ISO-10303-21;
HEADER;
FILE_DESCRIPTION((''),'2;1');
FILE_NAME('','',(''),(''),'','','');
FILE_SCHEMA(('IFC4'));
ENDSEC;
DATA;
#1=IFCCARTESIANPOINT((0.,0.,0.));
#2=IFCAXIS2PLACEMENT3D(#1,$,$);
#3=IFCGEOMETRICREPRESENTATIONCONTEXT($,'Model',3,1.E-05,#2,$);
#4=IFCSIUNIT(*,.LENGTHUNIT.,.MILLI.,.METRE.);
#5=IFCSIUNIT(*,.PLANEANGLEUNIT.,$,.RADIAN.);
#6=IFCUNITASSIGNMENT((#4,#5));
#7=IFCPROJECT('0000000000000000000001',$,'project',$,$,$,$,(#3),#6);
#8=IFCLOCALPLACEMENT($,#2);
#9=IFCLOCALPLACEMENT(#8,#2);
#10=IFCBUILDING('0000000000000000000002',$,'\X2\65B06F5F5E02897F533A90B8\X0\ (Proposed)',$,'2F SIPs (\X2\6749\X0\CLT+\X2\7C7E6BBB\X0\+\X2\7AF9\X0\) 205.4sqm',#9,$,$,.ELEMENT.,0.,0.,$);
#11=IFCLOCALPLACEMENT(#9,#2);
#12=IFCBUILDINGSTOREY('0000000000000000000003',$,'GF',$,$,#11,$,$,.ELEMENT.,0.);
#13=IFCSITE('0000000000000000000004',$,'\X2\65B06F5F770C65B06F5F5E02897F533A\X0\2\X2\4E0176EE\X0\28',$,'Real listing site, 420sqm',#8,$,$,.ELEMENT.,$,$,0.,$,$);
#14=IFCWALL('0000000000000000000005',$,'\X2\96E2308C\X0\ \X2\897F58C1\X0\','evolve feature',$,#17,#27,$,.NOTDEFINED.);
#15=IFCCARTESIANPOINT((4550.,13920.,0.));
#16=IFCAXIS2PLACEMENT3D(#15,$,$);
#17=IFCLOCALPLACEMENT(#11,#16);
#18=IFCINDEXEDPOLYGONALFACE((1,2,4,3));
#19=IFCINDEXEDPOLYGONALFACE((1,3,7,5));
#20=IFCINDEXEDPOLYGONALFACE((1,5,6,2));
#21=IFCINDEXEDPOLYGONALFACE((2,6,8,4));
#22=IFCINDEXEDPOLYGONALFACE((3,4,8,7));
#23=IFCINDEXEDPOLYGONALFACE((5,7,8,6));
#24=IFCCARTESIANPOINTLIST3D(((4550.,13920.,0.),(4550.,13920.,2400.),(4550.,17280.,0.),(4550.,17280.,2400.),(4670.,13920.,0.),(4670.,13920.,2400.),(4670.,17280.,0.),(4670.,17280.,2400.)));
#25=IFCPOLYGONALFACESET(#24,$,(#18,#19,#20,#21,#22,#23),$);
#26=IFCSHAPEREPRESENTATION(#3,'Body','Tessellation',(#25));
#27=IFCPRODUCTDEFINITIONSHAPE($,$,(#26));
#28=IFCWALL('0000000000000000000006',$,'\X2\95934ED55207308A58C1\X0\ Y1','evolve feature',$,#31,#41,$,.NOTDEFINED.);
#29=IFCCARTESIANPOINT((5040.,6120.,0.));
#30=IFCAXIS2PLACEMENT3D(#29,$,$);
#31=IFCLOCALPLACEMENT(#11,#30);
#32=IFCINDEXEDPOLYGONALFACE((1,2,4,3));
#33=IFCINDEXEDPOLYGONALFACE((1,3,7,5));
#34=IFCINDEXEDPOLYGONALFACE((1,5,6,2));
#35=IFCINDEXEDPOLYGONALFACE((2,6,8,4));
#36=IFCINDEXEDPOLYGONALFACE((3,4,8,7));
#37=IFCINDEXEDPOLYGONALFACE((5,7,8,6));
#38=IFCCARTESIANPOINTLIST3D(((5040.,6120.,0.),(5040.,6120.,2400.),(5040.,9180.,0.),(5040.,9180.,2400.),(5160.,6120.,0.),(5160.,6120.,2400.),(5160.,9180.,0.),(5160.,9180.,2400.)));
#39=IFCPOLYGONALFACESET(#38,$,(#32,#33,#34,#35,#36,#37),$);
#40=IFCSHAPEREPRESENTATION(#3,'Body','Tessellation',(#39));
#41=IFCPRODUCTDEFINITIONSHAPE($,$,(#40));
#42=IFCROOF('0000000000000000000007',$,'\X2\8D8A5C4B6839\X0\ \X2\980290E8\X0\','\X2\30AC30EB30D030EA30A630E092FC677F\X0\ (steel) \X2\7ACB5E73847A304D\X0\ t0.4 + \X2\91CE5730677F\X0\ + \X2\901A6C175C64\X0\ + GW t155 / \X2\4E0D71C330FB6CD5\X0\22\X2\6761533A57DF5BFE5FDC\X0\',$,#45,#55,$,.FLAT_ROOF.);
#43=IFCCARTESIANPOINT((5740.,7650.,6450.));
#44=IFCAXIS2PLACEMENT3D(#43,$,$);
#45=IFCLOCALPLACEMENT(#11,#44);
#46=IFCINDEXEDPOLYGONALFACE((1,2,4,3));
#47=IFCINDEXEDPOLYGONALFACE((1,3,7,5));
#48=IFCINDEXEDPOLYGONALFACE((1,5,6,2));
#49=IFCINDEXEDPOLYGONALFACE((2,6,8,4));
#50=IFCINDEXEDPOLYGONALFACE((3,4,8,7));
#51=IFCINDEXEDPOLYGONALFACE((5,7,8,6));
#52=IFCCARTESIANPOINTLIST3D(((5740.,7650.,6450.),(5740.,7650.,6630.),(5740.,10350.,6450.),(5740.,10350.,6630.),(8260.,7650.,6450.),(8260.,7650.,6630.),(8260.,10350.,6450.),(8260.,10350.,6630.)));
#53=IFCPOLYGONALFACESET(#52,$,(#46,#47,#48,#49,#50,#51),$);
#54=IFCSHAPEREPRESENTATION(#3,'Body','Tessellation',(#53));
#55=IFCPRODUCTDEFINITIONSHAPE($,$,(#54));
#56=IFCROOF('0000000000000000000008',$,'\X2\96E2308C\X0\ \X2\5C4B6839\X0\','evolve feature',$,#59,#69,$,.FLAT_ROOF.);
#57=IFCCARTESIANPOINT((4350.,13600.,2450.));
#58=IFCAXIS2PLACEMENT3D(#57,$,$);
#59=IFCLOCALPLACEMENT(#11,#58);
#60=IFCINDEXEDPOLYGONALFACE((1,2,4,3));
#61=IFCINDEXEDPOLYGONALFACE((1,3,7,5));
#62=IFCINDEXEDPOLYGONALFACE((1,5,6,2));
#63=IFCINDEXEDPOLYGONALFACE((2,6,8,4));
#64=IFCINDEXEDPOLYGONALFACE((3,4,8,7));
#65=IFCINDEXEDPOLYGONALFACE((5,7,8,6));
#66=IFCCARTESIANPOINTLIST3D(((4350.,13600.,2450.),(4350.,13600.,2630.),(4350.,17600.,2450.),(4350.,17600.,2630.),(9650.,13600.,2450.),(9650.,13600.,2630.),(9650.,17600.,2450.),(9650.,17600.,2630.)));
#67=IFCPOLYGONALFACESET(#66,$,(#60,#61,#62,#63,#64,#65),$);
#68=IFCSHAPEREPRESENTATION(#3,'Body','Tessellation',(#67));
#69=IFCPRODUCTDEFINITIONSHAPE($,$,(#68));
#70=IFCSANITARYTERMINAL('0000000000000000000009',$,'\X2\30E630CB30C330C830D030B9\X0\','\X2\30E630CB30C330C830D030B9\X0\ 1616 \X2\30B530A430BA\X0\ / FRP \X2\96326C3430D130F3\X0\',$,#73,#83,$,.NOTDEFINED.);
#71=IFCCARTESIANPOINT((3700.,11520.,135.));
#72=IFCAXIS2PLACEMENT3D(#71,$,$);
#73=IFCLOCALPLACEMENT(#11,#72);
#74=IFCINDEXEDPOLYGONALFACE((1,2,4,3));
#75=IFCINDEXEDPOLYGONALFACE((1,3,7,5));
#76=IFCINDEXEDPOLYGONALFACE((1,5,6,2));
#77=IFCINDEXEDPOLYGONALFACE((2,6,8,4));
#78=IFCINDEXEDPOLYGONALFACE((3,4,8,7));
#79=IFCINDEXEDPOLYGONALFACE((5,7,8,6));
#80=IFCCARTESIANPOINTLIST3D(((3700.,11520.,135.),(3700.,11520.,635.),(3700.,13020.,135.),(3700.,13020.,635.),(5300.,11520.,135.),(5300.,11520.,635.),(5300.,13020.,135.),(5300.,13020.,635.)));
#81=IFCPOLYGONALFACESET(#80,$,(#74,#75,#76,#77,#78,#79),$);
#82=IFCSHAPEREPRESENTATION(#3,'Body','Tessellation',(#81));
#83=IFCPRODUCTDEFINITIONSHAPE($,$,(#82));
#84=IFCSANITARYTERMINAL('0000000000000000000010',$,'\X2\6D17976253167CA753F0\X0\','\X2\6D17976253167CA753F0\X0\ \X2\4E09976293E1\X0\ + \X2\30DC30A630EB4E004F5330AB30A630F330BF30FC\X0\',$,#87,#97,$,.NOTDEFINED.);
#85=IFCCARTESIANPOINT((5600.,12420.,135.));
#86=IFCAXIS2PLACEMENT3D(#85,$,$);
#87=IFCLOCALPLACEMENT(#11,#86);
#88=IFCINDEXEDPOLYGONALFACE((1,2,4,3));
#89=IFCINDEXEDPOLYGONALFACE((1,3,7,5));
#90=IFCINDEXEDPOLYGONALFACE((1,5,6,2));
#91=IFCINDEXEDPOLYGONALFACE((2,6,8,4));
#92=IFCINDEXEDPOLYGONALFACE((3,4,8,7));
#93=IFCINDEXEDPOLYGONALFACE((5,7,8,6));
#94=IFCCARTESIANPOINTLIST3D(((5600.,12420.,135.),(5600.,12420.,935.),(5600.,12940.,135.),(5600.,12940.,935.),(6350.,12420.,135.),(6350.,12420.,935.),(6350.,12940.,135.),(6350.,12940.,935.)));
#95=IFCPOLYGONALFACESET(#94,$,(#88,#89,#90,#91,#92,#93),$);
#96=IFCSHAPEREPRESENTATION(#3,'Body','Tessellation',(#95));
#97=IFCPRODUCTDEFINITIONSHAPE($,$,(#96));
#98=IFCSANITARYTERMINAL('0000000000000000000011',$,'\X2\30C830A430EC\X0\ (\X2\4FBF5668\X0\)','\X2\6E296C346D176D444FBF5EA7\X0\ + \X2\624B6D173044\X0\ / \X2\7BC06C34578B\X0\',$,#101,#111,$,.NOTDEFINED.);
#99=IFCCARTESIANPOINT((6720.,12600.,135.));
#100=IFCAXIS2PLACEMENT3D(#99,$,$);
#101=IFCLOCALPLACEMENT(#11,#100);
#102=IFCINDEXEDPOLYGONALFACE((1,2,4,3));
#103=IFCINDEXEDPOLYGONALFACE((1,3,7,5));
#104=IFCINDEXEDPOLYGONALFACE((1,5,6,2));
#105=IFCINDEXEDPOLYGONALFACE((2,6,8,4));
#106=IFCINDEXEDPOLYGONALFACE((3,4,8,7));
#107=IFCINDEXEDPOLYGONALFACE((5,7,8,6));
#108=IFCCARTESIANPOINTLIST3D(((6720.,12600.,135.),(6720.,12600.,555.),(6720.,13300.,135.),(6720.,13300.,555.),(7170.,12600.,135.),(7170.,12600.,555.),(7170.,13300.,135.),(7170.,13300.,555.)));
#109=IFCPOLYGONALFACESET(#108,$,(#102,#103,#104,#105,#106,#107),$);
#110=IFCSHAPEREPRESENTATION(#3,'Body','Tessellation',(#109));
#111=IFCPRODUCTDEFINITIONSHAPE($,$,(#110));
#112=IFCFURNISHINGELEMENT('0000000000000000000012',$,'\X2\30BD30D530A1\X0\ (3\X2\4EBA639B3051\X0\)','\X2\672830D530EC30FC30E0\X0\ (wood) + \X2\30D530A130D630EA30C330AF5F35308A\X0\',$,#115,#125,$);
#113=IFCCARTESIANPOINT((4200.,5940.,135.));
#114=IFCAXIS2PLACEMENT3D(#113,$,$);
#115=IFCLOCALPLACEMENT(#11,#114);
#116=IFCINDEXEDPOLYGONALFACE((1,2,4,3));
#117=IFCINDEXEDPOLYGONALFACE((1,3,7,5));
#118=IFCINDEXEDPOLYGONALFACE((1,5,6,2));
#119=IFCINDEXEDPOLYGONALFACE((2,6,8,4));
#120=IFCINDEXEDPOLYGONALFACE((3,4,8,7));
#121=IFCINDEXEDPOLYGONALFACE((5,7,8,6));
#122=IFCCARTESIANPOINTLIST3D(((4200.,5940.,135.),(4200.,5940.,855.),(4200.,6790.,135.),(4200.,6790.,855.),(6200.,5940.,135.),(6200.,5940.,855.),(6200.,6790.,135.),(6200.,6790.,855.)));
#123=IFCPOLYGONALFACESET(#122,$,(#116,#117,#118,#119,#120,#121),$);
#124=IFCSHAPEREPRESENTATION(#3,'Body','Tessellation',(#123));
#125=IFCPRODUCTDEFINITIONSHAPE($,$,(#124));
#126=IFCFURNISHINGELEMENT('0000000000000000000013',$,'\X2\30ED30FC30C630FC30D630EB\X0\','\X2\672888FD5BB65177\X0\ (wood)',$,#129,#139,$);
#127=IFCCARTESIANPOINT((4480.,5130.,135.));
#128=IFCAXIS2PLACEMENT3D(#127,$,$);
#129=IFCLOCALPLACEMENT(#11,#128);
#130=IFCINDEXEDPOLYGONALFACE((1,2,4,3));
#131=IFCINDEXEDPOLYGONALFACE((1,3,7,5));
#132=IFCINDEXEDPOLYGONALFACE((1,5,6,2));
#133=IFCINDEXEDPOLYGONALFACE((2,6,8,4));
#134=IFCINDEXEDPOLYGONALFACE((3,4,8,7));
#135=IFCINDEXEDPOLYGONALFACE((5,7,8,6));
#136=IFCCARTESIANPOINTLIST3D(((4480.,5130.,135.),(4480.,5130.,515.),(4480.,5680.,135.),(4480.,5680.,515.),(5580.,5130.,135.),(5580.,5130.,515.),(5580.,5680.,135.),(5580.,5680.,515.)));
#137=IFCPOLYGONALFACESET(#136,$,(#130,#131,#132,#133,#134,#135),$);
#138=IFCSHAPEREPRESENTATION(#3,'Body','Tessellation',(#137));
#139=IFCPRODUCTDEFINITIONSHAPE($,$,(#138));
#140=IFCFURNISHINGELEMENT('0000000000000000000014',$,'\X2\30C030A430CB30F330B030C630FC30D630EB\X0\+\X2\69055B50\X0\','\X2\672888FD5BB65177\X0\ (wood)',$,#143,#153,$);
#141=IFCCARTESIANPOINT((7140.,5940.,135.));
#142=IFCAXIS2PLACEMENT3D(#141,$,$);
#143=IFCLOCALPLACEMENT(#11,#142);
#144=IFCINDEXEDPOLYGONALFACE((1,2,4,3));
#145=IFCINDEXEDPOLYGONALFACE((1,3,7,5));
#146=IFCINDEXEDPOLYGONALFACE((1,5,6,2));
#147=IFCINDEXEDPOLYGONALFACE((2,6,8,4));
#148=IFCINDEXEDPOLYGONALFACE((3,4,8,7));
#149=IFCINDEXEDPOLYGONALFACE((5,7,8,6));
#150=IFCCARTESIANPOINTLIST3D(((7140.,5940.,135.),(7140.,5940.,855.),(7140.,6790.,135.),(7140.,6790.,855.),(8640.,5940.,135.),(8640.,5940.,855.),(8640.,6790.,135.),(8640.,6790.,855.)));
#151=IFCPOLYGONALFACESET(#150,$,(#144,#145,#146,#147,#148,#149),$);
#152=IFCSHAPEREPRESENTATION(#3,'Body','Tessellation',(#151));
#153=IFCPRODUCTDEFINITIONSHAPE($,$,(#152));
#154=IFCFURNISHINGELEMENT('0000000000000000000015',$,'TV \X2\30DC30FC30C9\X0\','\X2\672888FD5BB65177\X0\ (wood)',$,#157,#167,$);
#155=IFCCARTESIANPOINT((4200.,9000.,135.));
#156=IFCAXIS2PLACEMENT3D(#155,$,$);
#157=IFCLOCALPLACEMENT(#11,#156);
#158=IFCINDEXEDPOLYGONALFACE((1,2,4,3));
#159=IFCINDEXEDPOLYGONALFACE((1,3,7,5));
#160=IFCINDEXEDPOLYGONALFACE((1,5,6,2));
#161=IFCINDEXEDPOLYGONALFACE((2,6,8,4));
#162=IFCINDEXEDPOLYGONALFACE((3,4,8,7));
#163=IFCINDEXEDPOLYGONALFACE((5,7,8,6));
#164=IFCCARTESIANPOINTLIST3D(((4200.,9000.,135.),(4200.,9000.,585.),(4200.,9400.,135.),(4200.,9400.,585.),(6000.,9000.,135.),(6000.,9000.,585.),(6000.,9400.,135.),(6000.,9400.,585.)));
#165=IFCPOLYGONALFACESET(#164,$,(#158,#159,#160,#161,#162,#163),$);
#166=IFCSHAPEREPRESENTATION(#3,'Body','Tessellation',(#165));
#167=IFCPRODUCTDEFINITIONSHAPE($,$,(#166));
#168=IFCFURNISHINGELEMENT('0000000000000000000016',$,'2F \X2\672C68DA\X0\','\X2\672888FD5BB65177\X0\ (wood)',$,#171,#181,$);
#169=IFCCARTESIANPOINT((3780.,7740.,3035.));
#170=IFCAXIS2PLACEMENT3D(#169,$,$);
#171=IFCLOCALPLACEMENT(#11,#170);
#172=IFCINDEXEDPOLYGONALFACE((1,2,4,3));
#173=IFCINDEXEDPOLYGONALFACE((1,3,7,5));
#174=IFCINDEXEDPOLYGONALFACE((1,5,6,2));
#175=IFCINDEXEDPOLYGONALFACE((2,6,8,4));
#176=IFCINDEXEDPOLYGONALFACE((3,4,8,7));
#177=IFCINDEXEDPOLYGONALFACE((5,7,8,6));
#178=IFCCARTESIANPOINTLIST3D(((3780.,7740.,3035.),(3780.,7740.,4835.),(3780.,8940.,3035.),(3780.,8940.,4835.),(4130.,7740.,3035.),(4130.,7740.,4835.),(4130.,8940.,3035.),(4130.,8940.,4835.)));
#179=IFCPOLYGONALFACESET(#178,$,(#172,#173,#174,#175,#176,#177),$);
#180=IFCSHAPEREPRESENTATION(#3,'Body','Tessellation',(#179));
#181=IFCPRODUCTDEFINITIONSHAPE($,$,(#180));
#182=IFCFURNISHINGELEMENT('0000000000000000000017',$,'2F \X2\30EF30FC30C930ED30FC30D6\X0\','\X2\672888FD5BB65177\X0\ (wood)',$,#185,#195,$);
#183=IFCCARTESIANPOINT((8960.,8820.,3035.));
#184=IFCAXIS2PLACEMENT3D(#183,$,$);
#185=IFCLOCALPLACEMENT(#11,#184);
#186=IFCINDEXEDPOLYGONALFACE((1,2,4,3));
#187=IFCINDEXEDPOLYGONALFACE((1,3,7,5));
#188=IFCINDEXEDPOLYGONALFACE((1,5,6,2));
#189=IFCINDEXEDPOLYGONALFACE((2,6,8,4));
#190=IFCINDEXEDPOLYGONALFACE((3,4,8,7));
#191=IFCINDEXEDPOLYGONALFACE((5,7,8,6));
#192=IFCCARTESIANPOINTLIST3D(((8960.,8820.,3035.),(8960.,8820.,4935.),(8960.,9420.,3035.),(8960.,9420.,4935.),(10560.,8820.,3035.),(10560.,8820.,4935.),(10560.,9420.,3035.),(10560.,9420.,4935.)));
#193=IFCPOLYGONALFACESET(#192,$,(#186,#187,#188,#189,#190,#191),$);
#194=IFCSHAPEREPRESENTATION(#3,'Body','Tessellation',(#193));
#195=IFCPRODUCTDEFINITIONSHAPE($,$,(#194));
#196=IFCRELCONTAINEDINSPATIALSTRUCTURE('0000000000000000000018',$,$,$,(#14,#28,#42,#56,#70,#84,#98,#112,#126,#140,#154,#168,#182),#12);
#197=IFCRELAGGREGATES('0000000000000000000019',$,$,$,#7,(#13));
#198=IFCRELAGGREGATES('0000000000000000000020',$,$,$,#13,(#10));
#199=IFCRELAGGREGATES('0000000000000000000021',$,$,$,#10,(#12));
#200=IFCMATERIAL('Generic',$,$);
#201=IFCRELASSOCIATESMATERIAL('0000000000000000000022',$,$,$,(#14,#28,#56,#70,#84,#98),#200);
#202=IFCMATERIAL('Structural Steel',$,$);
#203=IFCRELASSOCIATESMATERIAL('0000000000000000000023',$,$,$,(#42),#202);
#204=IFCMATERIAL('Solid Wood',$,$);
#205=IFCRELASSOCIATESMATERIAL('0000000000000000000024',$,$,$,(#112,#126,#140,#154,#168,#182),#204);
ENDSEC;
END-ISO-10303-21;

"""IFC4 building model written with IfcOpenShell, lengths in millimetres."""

from ifc_helpers import new_model, si_unit, frame, frame_2d, origin, place, context, project, spatial, rectangle, extrude, material, element, save


model = new_model("IFC4")

# Units and contexts
model_context = context("Model", 3, precision=1e-05, world=origin())
ifc_project = project(units=[si_unit("LENGTHUNIT", "METRE", prefix="MILLI"), si_unit("PLANEANGLEUNIT", "RADIAN")], contexts=[model_context])

# Site, building, storey
site_placement = place(None, origin())
site = spatial("IfcSite", under=ifc_project, at=site_placement, Name="新潟県新潟市西区2丁目28", ObjectType="Real listing site, 420sqm", CompositionType="ELEMENT", RefElevation=0.0)
building_placement = place(site_placement, origin())
building = spatial("IfcBuilding", under=site, at=building_placement, Name="新潟市西区邸 (Proposed)", ObjectType="2F SIPs (杉CLT+籾殻+竹) 205.4sqm", CompositionType="ELEMENT", ElevationOfRefHeight=0.0, ElevationOfTerrain=0.0)
storey_placement = place(building_placement, origin())
storey = spatial("IfcBuildingStorey", under=building, at=storey_placement, Name="GF", CompositionType="ELEMENT", Elevation=0.0)

# Shared definitions
ifc_material_1 = material(Name="Generic")

# Shared definitions
ifc_material_2 = material(Name="Solid Wood")

# Walls
wall_1_placement = place(storey_placement, frame((4550.0, 13920.0, 0.0)))
element("IfcWall", 1, at=wall_1_placement, inside=storey, material=ifc_material_1, Name="離れ 西壁", Description="evolve feature", PredefinedType="NOTDEFINED", context=model_context, shape_type="SweptSolid", body=[
    extrude(rectangle(XDim=120.0, YDim=3360.0, at=frame_2d((60.0, 1680.0))), frame((4550.0, 13920.0, 0.0)), (0.0, 0.0, 1.0), 2400.0),
])
wall_2_placement = place(storey_placement, frame((5040.0, 6120.0, 0.0)))
element("IfcWall", 2, at=wall_2_placement, inside=storey, material=ifc_material_1, Name="間仕切り壁 Y1", Description="evolve feature", PredefinedType="NOTDEFINED", context=model_context, shape_type="SweptSolid", body=[
    extrude(rectangle(XDim=120.0, YDim=3060.0, at=frame_2d((60.0, 1530.0))), frame((5040.0, 6120.0, 0.0)), (0.0, 0.0, 1.0), 2400.0),
])

# Roofs
ifc_material_3 = material(Name="Structural Steel")
roof_1_placement = place(storey_placement, frame((5740.0, 7650.0, 6450.0)))
element("IfcRoof", 3, at=roof_1_placement, inside=storey, material=ifc_material_3, Name="越屋根 頂部", Description="ガルバリウム鋼板 (steel) 立平葺き t0.4 + 野地板 + 通気層 + GW t155 / 不燃・法22条区域対応", PredefinedType="FLAT_ROOF", context=model_context, shape_type="SweptSolid", body=[
    extrude(rectangle(XDim=2520.0, YDim=2700.0, at=frame_2d((1260.0, 1350.0))), frame((5740.0, 7650.0, 6450.0)), (0.0, 0.0, 1.0), 180.0),
])
roof_2_placement = place(storey_placement, frame((4350.0, 13600.0, 2450.0)))
element("IfcRoof", 4, at=roof_2_placement, inside=storey, material=ifc_material_1, Name="離れ 屋根", Description="evolve feature", PredefinedType="FLAT_ROOF", context=model_context, shape_type="SweptSolid", body=[
    extrude(rectangle(XDim=5300.0, YDim=4000.0, at=frame_2d((2650.0, 2000.0))), frame((4350.0, 13600.0, 2450.0)), (0.0, 0.0, 1.0), 180.0),
])

# Sanitary terminals
sanitary_terminal_1_placement = place(storey_placement, frame((3700.0, 11520.0, 135.0)))
element("IfcSanitaryTerminal", 5, at=sanitary_terminal_1_placement, inside=storey, material=ifc_material_1, Name="ユニットバス", Description="ユニットバス 1616 サイズ / FRP 防水パン", PredefinedType="NOTDEFINED", context=model_context, shape_type="SweptSolid", body=[
    extrude(rectangle(XDim=1600.0, YDim=1500.0, at=frame_2d((800.0, 750.0))), frame((3700.0, 11520.0, 135.0)), (0.0, 0.0, 1.0), 500.0),
])
sanitary_terminal_2_placement = place(storey_placement, frame((5600.0, 12420.0, 135.0)))
element("IfcSanitaryTerminal", 6, at=sanitary_terminal_2_placement, inside=storey, material=ifc_material_1, Name="洗面化粧台", Description="洗面化粧台 三面鏡 + ボウル一体カウンター", PredefinedType="NOTDEFINED", context=model_context, shape_type="SweptSolid", body=[
    extrude(rectangle(XDim=750.0, YDim=520.0, at=frame_2d((375.0, 260.0))), frame((5600.0, 12420.0, 135.0)), (0.0, 0.0, 1.0), 800.0),
])
sanitary_terminal_3_placement = place(storey_placement, frame((6720.0, 12600.0, 135.0)))
element("IfcSanitaryTerminal", 7, at=sanitary_terminal_3_placement, inside=storey, material=ifc_material_1, Name="トイレ (便器)", Description="温水洗浄便座 + 手洗い / 節水型", PredefinedType="NOTDEFINED", context=model_context, shape_type="SweptSolid", body=[
    extrude(rectangle(XDim=450.0, YDim=700.0, at=frame_2d((225.0, 350.0))), frame((6720.0, 12600.0, 135.0)), (0.0, 0.0, 1.0), 420.0),
])

# Furnishing elements
furnishing_1_placement = place(storey_placement, frame((4200.0, 5940.0, 135.0)))
element("IfcFurnishingElement", 8, at=furnishing_1_placement, inside=storey, material=ifc_material_2, Name="ソファ (3人掛け)", Description="木フレーム (wood) + ファブリック張り", context=model_context, shape_type="SweptSolid", body=[
    extrude(rectangle(XDim=2000.0, YDim=850.0, at=frame_2d((1000.0, 425.0))), frame((4200.0, 5940.0, 135.0)), (0.0, 0.0, 1.0), 720.0),
])
furnishing_2_placement = place(storey_placement, frame((4480.0, 5130.0, 135.0)))
element("IfcFurnishingElement", 9, at=furnishing_2_placement, inside=storey, material=ifc_material_2, Name="ローテーブル", Description="木製家具 (wood)", context=model_context, shape_type="SweptSolid", body=[
    extrude(rectangle(XDim=1100.0, YDim=550.0, at=frame_2d((550.0, 275.0))), frame((4480.0, 5130.0, 135.0)), (0.0, 0.0, 1.0), 380.0),
])
furnishing_3_placement = place(storey_placement, frame((7140.0, 5940.0, 135.0)))
element("IfcFurnishingElement", 10, at=furnishing_3_placement, inside=storey, material=ifc_material_2, Name="ダイニングテーブル+椅子", Description="木製家具 (wood)", context=model_context, shape_type="SweptSolid", body=[
    extrude(rectangle(XDim=1500.0, YDim=850.0, at=frame_2d((750.0, 425.0))), frame((7140.0, 5940.0, 135.0)), (0.0, 0.0, 1.0), 720.0),
])
furnishing_4_placement = place(storey_placement, frame((4200.0, 9000.0, 135.0)))
element("IfcFurnishingElement", 11, at=furnishing_4_placement, inside=storey, material=ifc_material_2, Name="TV ボード", Description="木製家具 (wood)", context=model_context, shape_type="SweptSolid", body=[
    extrude(rectangle(XDim=1800.0, YDim=400.0, at=frame_2d((900.0, 200.0))), frame((4200.0, 9000.0, 135.0)), (0.0, 0.0, 1.0), 450.0),
])
furnishing_5_placement = place(storey_placement, frame((3780.0, 7740.0, 3035.0)))
element("IfcFurnishingElement", 12, at=furnishing_5_placement, inside=storey, material=ifc_material_2, Name="2F 本棚", Description="木製家具 (wood)", context=model_context, shape_type="SweptSolid", body=[
    extrude(rectangle(XDim=350.0, YDim=1200.0, at=frame_2d((175.0, 600.0))), frame((3780.0, 7740.0, 3035.0)), (0.0, 0.0, 1.0), 1800.0),
])
furnishing_6_placement = place(storey_placement, frame((8960.0, 8820.0, 3035.0)))
element("IfcFurnishingElement", 13, at=furnishing_6_placement, inside=storey, material=ifc_material_2, Name="2F ワードローブ", Description="木製家具 (wood)", context=model_context, shape_type="SweptSolid", body=[
    extrude(rectangle(XDim=1600.0, YDim=600.0, at=frame_2d((800.0, 300.0))), frame((8960.0, 8820.0, 3035.0)), (0.0, 0.0, 1.0), 1900.0),
])

save(model, "model.ifc")
